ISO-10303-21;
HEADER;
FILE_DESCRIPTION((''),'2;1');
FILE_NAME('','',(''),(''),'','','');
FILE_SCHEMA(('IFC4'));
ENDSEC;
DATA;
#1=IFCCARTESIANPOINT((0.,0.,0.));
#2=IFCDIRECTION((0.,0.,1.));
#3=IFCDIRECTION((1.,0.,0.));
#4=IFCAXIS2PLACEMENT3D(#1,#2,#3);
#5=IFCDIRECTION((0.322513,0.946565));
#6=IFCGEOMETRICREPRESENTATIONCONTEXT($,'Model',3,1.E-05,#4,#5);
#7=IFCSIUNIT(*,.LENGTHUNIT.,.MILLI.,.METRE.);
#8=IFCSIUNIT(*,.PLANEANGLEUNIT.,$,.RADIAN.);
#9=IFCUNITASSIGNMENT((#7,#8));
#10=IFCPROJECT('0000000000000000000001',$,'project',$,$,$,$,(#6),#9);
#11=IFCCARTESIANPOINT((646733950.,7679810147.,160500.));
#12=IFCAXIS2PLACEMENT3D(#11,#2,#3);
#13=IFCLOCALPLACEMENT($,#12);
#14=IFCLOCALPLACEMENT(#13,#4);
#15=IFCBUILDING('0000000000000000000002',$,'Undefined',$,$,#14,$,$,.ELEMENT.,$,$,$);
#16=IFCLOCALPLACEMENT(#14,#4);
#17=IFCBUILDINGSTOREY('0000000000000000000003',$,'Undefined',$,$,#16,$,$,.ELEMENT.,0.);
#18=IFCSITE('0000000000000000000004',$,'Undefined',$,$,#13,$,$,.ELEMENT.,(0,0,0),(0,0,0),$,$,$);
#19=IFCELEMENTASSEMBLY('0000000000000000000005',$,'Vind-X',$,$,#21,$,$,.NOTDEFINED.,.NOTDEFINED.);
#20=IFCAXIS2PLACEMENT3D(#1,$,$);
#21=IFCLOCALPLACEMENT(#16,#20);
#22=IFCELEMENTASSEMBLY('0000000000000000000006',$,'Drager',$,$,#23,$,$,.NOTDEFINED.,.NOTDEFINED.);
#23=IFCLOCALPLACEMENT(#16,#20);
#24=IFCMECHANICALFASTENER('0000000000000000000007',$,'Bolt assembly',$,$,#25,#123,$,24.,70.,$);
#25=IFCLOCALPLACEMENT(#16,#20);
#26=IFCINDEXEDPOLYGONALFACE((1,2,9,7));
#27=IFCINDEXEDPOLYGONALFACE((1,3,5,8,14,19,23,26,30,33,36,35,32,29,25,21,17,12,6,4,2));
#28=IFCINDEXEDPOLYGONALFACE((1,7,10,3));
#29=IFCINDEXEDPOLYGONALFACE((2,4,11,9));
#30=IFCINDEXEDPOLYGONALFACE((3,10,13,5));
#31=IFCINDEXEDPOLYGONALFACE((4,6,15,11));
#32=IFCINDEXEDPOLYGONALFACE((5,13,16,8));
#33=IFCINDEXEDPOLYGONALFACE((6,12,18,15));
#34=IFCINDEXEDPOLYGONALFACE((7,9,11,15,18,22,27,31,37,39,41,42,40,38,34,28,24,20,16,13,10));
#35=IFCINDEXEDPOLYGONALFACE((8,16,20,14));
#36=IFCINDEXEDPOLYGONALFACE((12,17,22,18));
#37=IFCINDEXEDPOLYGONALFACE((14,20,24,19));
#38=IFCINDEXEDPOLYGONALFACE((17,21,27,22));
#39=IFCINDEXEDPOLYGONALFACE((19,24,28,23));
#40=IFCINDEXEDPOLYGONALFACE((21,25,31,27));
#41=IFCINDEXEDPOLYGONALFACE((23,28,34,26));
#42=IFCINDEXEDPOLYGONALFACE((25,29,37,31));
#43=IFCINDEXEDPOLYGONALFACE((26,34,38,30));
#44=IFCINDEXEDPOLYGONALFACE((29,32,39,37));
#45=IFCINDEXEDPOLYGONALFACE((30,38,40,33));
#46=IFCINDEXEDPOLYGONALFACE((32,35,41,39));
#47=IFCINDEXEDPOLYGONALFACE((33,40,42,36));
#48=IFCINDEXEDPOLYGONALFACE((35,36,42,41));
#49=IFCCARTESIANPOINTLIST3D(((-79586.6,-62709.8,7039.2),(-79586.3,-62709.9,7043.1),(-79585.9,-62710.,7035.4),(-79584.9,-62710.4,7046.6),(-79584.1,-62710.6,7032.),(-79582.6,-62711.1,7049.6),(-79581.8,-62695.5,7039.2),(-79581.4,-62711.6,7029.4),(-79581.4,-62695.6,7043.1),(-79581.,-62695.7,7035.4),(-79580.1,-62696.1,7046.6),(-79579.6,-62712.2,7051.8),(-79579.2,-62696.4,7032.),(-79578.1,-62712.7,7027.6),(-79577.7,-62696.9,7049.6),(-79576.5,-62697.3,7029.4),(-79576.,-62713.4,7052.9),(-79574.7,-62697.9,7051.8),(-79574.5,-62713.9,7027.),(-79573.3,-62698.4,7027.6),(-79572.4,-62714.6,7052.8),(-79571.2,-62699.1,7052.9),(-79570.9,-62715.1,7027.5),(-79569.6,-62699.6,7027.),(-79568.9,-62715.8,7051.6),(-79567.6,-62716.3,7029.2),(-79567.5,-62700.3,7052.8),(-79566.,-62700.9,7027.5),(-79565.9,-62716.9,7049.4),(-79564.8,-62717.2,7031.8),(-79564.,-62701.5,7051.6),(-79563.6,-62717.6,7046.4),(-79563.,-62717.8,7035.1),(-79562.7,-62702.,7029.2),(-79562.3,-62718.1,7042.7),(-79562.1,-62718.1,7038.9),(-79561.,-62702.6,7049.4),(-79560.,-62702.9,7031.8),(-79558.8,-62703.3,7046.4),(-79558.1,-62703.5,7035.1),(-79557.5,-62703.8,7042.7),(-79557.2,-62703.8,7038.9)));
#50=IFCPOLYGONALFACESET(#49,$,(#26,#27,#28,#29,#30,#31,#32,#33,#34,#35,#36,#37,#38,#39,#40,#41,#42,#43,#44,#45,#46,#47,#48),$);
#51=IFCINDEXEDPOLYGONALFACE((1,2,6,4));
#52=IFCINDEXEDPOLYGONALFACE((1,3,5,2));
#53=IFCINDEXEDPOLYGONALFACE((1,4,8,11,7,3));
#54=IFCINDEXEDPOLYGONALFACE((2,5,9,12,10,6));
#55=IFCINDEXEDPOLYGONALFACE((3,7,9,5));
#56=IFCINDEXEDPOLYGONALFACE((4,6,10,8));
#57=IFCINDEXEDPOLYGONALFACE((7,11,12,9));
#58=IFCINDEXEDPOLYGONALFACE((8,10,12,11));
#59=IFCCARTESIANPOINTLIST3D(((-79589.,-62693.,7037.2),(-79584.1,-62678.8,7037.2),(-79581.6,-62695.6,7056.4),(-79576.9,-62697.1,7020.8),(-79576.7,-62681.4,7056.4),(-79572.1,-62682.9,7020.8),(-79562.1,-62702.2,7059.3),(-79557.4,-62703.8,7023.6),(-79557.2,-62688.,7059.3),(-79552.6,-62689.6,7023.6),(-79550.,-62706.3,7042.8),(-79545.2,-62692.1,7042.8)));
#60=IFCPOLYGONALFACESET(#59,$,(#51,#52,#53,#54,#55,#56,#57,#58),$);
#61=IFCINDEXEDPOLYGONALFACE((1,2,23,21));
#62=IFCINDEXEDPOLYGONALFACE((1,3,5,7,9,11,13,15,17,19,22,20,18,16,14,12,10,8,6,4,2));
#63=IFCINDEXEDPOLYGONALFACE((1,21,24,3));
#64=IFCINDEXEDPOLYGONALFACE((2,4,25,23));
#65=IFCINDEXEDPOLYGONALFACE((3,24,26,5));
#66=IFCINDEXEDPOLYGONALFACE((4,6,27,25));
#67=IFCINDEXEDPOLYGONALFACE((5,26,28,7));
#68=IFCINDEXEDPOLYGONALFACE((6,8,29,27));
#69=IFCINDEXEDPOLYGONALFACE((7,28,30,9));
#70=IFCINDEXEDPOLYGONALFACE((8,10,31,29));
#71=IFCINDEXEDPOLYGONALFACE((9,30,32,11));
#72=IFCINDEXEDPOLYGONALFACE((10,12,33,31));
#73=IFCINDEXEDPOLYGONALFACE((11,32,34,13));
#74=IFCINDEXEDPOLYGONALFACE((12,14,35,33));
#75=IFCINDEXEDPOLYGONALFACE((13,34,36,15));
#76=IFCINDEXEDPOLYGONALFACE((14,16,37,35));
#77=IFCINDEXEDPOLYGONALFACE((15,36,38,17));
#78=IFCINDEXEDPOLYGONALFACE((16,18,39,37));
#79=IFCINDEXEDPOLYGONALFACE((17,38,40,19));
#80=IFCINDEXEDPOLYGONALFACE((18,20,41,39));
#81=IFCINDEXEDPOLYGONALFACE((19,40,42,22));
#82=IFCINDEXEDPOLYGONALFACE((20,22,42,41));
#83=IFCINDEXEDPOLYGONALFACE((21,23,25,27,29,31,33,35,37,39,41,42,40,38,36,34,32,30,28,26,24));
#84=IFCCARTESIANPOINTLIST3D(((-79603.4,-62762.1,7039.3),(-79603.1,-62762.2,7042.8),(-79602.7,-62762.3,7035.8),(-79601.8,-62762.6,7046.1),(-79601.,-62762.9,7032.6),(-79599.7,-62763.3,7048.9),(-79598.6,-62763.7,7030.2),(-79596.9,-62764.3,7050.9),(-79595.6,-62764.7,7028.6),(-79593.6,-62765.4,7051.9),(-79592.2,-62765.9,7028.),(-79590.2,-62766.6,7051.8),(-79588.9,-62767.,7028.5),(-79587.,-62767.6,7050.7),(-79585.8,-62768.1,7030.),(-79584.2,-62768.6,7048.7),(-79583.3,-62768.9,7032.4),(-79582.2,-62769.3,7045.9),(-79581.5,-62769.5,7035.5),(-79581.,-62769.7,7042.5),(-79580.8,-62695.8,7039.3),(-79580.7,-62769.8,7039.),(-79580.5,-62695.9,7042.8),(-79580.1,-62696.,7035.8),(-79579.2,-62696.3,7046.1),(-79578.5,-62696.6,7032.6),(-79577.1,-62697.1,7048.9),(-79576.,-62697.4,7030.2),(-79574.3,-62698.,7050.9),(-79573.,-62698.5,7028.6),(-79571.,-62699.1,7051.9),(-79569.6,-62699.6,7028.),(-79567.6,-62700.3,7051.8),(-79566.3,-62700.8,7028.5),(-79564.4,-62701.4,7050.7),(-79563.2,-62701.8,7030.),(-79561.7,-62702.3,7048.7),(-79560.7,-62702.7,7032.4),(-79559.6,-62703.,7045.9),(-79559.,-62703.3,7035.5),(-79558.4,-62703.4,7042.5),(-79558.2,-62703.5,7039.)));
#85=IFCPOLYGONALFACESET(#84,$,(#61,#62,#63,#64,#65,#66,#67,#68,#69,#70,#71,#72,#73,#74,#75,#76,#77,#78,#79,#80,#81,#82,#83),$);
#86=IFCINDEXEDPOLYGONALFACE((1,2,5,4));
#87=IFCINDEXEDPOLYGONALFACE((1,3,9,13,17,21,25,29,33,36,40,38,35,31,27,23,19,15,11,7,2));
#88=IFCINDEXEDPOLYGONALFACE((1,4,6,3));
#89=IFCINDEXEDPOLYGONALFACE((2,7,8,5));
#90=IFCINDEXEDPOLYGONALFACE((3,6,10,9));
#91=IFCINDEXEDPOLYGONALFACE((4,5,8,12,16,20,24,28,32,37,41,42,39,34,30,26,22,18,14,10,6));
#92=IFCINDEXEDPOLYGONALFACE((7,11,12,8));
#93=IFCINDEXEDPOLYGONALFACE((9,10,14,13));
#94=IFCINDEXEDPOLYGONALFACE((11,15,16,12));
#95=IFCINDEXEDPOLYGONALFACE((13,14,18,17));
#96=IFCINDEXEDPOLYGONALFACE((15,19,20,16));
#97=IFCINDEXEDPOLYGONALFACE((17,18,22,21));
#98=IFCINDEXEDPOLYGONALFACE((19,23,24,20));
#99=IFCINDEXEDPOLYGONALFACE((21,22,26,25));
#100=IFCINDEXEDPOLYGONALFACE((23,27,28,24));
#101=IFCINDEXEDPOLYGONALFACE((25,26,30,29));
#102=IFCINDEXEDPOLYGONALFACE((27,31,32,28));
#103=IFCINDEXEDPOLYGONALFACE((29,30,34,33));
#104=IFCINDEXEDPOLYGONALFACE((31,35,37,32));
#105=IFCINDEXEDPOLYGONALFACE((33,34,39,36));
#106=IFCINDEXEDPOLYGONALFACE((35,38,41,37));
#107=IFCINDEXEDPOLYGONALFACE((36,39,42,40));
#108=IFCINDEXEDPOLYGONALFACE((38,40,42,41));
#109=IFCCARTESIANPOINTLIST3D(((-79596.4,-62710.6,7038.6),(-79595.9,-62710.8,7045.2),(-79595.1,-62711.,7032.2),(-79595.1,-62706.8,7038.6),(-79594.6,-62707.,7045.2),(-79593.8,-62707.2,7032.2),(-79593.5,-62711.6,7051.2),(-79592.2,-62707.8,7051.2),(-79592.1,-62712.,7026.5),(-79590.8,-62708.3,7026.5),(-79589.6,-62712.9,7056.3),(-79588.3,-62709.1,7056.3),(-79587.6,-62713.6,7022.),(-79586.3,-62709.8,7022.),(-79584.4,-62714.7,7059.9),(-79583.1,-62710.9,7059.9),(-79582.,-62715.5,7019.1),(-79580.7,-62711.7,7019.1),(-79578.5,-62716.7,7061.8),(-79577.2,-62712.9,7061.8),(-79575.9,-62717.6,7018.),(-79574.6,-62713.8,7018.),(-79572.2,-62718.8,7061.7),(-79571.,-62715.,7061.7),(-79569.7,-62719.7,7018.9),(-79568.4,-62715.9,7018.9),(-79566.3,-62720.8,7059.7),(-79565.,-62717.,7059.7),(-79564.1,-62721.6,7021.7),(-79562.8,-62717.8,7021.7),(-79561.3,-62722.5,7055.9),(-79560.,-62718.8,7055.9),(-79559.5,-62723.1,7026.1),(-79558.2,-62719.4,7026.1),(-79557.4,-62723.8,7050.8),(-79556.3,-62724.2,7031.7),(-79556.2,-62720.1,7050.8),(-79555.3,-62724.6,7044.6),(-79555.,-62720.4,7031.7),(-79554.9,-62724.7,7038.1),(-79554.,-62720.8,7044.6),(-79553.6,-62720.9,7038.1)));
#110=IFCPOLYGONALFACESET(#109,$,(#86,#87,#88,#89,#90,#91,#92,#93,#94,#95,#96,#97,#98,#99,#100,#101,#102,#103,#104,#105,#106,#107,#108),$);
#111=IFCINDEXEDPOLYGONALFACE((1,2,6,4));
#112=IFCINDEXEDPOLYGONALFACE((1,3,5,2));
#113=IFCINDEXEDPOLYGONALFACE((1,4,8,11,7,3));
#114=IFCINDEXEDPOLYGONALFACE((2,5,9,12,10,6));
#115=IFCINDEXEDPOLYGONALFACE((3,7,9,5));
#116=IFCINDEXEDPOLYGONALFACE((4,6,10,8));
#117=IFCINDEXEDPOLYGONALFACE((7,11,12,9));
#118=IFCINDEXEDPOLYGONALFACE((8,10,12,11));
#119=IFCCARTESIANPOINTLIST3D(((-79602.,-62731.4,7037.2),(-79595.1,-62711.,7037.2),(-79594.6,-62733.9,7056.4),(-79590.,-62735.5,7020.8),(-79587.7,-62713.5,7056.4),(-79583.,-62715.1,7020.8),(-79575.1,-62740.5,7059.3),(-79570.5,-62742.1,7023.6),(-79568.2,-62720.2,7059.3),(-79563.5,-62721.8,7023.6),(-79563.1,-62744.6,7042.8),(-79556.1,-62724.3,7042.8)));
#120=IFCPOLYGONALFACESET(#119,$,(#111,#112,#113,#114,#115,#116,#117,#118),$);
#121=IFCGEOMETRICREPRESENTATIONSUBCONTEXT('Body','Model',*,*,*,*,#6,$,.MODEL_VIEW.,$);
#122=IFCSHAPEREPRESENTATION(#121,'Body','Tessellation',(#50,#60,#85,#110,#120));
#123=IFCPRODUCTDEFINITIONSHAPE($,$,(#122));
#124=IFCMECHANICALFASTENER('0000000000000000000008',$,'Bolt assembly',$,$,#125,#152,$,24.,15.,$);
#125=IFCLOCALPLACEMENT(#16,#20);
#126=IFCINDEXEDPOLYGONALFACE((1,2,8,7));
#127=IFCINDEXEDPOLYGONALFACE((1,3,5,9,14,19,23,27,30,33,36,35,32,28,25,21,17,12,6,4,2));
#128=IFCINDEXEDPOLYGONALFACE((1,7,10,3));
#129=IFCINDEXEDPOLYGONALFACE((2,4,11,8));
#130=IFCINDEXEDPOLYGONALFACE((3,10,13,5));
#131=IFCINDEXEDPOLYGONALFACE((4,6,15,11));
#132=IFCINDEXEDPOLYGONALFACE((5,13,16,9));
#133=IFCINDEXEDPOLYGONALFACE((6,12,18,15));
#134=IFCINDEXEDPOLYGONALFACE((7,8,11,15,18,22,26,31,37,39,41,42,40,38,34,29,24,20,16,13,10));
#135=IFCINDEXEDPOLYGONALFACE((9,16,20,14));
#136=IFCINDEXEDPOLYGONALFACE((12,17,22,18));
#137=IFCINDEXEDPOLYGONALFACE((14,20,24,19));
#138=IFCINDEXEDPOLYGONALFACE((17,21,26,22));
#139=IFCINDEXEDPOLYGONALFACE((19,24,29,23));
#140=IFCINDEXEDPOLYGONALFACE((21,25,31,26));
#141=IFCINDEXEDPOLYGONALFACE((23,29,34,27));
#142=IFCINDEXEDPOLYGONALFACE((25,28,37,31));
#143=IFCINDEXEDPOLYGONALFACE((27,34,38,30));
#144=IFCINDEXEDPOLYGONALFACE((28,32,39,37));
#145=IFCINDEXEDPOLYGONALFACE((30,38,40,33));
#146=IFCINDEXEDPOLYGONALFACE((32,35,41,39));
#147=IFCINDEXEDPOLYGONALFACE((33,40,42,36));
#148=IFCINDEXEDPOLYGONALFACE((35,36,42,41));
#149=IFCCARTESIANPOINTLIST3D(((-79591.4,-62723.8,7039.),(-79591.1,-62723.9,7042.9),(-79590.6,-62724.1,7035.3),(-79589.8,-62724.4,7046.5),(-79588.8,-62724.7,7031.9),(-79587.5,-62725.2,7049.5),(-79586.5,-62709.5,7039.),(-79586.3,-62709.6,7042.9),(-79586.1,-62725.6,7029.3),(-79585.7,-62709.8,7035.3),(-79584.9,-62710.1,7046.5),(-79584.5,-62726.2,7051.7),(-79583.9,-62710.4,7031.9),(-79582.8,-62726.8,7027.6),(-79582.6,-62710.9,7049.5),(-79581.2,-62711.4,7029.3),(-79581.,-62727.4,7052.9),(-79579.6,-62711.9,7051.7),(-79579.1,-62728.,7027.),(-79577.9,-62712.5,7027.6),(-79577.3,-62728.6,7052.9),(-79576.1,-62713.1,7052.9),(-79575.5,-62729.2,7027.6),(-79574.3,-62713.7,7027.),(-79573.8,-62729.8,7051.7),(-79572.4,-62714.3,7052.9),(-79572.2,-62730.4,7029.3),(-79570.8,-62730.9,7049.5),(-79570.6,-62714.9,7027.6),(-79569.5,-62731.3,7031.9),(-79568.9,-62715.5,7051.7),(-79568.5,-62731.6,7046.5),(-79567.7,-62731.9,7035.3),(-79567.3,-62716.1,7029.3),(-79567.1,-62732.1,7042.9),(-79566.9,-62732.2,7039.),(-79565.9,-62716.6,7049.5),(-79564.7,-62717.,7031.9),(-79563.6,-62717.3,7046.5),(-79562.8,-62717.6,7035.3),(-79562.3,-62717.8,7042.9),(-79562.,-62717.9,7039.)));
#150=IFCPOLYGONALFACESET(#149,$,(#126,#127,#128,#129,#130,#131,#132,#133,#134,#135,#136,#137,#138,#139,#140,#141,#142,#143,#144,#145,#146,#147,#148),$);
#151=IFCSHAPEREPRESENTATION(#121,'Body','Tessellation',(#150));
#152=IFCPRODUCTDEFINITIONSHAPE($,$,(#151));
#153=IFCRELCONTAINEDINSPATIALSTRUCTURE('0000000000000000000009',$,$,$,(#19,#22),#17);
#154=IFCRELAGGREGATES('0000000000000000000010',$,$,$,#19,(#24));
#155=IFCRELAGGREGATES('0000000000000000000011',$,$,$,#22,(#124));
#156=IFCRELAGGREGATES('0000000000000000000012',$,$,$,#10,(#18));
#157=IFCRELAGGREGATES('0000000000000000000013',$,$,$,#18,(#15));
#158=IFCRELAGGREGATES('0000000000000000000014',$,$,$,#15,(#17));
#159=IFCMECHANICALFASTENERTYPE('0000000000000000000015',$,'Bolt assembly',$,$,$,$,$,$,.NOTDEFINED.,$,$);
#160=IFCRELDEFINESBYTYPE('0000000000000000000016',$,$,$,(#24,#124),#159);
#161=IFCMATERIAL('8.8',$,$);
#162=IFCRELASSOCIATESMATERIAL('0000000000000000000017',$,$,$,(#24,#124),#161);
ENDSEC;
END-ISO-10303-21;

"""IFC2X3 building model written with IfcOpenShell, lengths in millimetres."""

from ifc_helpers import new_model, si_unit, direction, frame, origin_with_axes, origin_2d_with_axis, place, context, subcontext, project, spatial, polyline, circle, outline, extrude, source, transform, mapped, material, type_object, element, aggregate, save


model = new_model("IFC2X3")

# Units and contexts
model_context = context("Model", 3, precision=1e-05, world=origin_with_axes(), true_north=direction((0.322513, 0.946565)))
body_context = subcontext(model_context, "Body", "Model", "MODEL_VIEW")
ifc_project = project(units=[si_unit("LENGTHUNIT", "METRE", prefix="MILLI"), si_unit("PLANEANGLEUNIT", "RADIAN")], contexts=[model_context])

# Site, building, storey
site_placement = place(None, frame((646733950.0, 7679810147.0, 160500.0), z_axis=(0.0, 0.0, 1.0), x_axis=(1.0, 0.0, 0.0)))
site = spatial("IfcSite", under=ifc_project, at=site_placement, Name="Undefined", CompositionType="ELEMENT", RefLatitude=(0, 0, 0), RefLongitude=(0, 0, 0))
building_placement = place(site_placement, origin_with_axes())
building = spatial("IfcBuilding", under=site, at=building_placement, Name="Undefined", CompositionType="ELEMENT")
storey_placement = place(building_placement, origin_with_axes())
storey = spatial("IfcBuildingStorey", under=building, at=storey_placement, Name="Undefined", CompositionType="ELEMENT", Elevation=0.0)

# Element assembly
assembly_1_placement = place(storey_placement, origin_with_axes())
assembly_1 = element("IfcElementAssembly", 1, at=assembly_1_placement, inside=storey, Name="Vind-X", AssemblyPlace="NOTDEFINED", PredefinedType="NOTDEFINED")

# Element assembly
assembly_2_placement = place(storey_placement, origin_with_axes())
assembly_2 = element("IfcElementAssembly", 2, at=assembly_2_placement, inside=storey, Name="Drager", AssemblyPlace="NOTDEFINED", PredefinedType="NOTDEFINED")

# Shared definitions
ifc_material_1 = material(Name="8.8")
mechanical_fastener_type = type_object("IfcMechanicalFastenerType", Name="Bolt assembly")

# Shared definitions
shared_shape_1 = source(origin_with_axes(), body_context, "Body", "SweptSolid", [
    extrude(circle(Radius=13.0, at=origin_2d_with_axis()), frame((0.0, 0.0, 0.0), z_axis=(0.0, 1.0, 0.0), x_axis=(1.0, 0.0, 0.0)), (0.0, 0.0, 1.0), 15.1),
    extrude(outline(polyline([(18.0, -10.4), (18.0, 10.4), (0.0, 20.8), (-18.0, 10.4), (-18.0, -10.4), (0.0, -20.8), (18.0, -10.4)])), frame((0.0, -15.0, 0.0), z_axis=(0.0, 1.0, 0.0), x_axis=(1.0, 0.0, 0.0)), (0.0, 0.0, 1.0), 15.0),
    extrude(circle(Radius=12.0, at=origin_2d_with_axis()), frame((0.0, 0.0, 0.0), z_axis=(0.0, 1.0, 0.0), x_axis=(1.0, 0.0, 0.0)), (0.0, 0.0, 1.0), 70.0),
    extrude(circle(Radius=22.0, at=origin_2d_with_axis()), frame((0.0, 15.0, 0.0), z_axis=(0.0, 1.0, 0.0), x_axis=(1.0, 0.0, 0.0)), (0.0, 0.0, 1.0), 4.0),
    extrude(outline(polyline([(18.0, -10.4), (18.0, 10.4), (0.0, 20.8), (-18.0, 10.4), (-18.0, -10.4), (0.0, -20.8), (18.0, -10.4)])), frame((0.0, 19.0, 0.0), z_axis=(0.0, 1.0, 0.0), x_axis=(1.0, 0.0, 0.0)), (0.0, 0.0, 1.0), 21.5),
])

# Mechanical fasteners
mechanical_fastener_1_placement = place(assembly_1_placement, frame((-79569.5, -62699.7, 7040.0), z_axis=(-0.580575, 0.197813, 0.789812), x_axis=(-0.747608, 0.254725, -0.613349)))
mechanical_fastener_1 = element("IfcMechanicalFastener", 3, at=mechanical_fastener_1_placement, type_object=mechanical_fastener_type, material=ifc_material_1, Name="Bolt assembly", NominalDiameter=24.0, NominalLength=70.0, context=body_context, shape_type="MappedRepresentation", body=[
    mapped(shared_shape_1, transform((0.0, 0.0, 0.0))),
])
aggregate(assembly_1, [mechanical_fastener_1])
shared_shape_2 = source(origin_with_axes(), body_context, "Body", "SweptSolid", [
    extrude(circle(Radius=13.0, at=origin_2d_with_axis()), frame((0.0, -7.4, 0.0), z_axis=(0.0, 1.0, 0.0), x_axis=(1.0, 0.0, 0.0)), (0.0, 0.0, 1.0), 15.1),
])
mechanical_fastener_2_placement = place(assembly_2_placement, frame((-79576.7, -62721.0, 7040.0), z_axis=(0.946565, -0.322513, 0.0), x_axis=(0.0, 0.0, -1.0)))
mechanical_fastener_2 = element("IfcMechanicalFastener", 4, at=mechanical_fastener_2_placement, type_object=mechanical_fastener_type, material=ifc_material_1, Name="Bolt assembly", NominalDiameter=24.0, NominalLength=15.0, context=body_context, shape_type="MappedRepresentation", body=[
    mapped(shared_shape_2, transform((0.0, 0.0, 0.0))),
])
aggregate(assembly_2, [mechanical_fastener_2])

save(model, "model.ifc")
